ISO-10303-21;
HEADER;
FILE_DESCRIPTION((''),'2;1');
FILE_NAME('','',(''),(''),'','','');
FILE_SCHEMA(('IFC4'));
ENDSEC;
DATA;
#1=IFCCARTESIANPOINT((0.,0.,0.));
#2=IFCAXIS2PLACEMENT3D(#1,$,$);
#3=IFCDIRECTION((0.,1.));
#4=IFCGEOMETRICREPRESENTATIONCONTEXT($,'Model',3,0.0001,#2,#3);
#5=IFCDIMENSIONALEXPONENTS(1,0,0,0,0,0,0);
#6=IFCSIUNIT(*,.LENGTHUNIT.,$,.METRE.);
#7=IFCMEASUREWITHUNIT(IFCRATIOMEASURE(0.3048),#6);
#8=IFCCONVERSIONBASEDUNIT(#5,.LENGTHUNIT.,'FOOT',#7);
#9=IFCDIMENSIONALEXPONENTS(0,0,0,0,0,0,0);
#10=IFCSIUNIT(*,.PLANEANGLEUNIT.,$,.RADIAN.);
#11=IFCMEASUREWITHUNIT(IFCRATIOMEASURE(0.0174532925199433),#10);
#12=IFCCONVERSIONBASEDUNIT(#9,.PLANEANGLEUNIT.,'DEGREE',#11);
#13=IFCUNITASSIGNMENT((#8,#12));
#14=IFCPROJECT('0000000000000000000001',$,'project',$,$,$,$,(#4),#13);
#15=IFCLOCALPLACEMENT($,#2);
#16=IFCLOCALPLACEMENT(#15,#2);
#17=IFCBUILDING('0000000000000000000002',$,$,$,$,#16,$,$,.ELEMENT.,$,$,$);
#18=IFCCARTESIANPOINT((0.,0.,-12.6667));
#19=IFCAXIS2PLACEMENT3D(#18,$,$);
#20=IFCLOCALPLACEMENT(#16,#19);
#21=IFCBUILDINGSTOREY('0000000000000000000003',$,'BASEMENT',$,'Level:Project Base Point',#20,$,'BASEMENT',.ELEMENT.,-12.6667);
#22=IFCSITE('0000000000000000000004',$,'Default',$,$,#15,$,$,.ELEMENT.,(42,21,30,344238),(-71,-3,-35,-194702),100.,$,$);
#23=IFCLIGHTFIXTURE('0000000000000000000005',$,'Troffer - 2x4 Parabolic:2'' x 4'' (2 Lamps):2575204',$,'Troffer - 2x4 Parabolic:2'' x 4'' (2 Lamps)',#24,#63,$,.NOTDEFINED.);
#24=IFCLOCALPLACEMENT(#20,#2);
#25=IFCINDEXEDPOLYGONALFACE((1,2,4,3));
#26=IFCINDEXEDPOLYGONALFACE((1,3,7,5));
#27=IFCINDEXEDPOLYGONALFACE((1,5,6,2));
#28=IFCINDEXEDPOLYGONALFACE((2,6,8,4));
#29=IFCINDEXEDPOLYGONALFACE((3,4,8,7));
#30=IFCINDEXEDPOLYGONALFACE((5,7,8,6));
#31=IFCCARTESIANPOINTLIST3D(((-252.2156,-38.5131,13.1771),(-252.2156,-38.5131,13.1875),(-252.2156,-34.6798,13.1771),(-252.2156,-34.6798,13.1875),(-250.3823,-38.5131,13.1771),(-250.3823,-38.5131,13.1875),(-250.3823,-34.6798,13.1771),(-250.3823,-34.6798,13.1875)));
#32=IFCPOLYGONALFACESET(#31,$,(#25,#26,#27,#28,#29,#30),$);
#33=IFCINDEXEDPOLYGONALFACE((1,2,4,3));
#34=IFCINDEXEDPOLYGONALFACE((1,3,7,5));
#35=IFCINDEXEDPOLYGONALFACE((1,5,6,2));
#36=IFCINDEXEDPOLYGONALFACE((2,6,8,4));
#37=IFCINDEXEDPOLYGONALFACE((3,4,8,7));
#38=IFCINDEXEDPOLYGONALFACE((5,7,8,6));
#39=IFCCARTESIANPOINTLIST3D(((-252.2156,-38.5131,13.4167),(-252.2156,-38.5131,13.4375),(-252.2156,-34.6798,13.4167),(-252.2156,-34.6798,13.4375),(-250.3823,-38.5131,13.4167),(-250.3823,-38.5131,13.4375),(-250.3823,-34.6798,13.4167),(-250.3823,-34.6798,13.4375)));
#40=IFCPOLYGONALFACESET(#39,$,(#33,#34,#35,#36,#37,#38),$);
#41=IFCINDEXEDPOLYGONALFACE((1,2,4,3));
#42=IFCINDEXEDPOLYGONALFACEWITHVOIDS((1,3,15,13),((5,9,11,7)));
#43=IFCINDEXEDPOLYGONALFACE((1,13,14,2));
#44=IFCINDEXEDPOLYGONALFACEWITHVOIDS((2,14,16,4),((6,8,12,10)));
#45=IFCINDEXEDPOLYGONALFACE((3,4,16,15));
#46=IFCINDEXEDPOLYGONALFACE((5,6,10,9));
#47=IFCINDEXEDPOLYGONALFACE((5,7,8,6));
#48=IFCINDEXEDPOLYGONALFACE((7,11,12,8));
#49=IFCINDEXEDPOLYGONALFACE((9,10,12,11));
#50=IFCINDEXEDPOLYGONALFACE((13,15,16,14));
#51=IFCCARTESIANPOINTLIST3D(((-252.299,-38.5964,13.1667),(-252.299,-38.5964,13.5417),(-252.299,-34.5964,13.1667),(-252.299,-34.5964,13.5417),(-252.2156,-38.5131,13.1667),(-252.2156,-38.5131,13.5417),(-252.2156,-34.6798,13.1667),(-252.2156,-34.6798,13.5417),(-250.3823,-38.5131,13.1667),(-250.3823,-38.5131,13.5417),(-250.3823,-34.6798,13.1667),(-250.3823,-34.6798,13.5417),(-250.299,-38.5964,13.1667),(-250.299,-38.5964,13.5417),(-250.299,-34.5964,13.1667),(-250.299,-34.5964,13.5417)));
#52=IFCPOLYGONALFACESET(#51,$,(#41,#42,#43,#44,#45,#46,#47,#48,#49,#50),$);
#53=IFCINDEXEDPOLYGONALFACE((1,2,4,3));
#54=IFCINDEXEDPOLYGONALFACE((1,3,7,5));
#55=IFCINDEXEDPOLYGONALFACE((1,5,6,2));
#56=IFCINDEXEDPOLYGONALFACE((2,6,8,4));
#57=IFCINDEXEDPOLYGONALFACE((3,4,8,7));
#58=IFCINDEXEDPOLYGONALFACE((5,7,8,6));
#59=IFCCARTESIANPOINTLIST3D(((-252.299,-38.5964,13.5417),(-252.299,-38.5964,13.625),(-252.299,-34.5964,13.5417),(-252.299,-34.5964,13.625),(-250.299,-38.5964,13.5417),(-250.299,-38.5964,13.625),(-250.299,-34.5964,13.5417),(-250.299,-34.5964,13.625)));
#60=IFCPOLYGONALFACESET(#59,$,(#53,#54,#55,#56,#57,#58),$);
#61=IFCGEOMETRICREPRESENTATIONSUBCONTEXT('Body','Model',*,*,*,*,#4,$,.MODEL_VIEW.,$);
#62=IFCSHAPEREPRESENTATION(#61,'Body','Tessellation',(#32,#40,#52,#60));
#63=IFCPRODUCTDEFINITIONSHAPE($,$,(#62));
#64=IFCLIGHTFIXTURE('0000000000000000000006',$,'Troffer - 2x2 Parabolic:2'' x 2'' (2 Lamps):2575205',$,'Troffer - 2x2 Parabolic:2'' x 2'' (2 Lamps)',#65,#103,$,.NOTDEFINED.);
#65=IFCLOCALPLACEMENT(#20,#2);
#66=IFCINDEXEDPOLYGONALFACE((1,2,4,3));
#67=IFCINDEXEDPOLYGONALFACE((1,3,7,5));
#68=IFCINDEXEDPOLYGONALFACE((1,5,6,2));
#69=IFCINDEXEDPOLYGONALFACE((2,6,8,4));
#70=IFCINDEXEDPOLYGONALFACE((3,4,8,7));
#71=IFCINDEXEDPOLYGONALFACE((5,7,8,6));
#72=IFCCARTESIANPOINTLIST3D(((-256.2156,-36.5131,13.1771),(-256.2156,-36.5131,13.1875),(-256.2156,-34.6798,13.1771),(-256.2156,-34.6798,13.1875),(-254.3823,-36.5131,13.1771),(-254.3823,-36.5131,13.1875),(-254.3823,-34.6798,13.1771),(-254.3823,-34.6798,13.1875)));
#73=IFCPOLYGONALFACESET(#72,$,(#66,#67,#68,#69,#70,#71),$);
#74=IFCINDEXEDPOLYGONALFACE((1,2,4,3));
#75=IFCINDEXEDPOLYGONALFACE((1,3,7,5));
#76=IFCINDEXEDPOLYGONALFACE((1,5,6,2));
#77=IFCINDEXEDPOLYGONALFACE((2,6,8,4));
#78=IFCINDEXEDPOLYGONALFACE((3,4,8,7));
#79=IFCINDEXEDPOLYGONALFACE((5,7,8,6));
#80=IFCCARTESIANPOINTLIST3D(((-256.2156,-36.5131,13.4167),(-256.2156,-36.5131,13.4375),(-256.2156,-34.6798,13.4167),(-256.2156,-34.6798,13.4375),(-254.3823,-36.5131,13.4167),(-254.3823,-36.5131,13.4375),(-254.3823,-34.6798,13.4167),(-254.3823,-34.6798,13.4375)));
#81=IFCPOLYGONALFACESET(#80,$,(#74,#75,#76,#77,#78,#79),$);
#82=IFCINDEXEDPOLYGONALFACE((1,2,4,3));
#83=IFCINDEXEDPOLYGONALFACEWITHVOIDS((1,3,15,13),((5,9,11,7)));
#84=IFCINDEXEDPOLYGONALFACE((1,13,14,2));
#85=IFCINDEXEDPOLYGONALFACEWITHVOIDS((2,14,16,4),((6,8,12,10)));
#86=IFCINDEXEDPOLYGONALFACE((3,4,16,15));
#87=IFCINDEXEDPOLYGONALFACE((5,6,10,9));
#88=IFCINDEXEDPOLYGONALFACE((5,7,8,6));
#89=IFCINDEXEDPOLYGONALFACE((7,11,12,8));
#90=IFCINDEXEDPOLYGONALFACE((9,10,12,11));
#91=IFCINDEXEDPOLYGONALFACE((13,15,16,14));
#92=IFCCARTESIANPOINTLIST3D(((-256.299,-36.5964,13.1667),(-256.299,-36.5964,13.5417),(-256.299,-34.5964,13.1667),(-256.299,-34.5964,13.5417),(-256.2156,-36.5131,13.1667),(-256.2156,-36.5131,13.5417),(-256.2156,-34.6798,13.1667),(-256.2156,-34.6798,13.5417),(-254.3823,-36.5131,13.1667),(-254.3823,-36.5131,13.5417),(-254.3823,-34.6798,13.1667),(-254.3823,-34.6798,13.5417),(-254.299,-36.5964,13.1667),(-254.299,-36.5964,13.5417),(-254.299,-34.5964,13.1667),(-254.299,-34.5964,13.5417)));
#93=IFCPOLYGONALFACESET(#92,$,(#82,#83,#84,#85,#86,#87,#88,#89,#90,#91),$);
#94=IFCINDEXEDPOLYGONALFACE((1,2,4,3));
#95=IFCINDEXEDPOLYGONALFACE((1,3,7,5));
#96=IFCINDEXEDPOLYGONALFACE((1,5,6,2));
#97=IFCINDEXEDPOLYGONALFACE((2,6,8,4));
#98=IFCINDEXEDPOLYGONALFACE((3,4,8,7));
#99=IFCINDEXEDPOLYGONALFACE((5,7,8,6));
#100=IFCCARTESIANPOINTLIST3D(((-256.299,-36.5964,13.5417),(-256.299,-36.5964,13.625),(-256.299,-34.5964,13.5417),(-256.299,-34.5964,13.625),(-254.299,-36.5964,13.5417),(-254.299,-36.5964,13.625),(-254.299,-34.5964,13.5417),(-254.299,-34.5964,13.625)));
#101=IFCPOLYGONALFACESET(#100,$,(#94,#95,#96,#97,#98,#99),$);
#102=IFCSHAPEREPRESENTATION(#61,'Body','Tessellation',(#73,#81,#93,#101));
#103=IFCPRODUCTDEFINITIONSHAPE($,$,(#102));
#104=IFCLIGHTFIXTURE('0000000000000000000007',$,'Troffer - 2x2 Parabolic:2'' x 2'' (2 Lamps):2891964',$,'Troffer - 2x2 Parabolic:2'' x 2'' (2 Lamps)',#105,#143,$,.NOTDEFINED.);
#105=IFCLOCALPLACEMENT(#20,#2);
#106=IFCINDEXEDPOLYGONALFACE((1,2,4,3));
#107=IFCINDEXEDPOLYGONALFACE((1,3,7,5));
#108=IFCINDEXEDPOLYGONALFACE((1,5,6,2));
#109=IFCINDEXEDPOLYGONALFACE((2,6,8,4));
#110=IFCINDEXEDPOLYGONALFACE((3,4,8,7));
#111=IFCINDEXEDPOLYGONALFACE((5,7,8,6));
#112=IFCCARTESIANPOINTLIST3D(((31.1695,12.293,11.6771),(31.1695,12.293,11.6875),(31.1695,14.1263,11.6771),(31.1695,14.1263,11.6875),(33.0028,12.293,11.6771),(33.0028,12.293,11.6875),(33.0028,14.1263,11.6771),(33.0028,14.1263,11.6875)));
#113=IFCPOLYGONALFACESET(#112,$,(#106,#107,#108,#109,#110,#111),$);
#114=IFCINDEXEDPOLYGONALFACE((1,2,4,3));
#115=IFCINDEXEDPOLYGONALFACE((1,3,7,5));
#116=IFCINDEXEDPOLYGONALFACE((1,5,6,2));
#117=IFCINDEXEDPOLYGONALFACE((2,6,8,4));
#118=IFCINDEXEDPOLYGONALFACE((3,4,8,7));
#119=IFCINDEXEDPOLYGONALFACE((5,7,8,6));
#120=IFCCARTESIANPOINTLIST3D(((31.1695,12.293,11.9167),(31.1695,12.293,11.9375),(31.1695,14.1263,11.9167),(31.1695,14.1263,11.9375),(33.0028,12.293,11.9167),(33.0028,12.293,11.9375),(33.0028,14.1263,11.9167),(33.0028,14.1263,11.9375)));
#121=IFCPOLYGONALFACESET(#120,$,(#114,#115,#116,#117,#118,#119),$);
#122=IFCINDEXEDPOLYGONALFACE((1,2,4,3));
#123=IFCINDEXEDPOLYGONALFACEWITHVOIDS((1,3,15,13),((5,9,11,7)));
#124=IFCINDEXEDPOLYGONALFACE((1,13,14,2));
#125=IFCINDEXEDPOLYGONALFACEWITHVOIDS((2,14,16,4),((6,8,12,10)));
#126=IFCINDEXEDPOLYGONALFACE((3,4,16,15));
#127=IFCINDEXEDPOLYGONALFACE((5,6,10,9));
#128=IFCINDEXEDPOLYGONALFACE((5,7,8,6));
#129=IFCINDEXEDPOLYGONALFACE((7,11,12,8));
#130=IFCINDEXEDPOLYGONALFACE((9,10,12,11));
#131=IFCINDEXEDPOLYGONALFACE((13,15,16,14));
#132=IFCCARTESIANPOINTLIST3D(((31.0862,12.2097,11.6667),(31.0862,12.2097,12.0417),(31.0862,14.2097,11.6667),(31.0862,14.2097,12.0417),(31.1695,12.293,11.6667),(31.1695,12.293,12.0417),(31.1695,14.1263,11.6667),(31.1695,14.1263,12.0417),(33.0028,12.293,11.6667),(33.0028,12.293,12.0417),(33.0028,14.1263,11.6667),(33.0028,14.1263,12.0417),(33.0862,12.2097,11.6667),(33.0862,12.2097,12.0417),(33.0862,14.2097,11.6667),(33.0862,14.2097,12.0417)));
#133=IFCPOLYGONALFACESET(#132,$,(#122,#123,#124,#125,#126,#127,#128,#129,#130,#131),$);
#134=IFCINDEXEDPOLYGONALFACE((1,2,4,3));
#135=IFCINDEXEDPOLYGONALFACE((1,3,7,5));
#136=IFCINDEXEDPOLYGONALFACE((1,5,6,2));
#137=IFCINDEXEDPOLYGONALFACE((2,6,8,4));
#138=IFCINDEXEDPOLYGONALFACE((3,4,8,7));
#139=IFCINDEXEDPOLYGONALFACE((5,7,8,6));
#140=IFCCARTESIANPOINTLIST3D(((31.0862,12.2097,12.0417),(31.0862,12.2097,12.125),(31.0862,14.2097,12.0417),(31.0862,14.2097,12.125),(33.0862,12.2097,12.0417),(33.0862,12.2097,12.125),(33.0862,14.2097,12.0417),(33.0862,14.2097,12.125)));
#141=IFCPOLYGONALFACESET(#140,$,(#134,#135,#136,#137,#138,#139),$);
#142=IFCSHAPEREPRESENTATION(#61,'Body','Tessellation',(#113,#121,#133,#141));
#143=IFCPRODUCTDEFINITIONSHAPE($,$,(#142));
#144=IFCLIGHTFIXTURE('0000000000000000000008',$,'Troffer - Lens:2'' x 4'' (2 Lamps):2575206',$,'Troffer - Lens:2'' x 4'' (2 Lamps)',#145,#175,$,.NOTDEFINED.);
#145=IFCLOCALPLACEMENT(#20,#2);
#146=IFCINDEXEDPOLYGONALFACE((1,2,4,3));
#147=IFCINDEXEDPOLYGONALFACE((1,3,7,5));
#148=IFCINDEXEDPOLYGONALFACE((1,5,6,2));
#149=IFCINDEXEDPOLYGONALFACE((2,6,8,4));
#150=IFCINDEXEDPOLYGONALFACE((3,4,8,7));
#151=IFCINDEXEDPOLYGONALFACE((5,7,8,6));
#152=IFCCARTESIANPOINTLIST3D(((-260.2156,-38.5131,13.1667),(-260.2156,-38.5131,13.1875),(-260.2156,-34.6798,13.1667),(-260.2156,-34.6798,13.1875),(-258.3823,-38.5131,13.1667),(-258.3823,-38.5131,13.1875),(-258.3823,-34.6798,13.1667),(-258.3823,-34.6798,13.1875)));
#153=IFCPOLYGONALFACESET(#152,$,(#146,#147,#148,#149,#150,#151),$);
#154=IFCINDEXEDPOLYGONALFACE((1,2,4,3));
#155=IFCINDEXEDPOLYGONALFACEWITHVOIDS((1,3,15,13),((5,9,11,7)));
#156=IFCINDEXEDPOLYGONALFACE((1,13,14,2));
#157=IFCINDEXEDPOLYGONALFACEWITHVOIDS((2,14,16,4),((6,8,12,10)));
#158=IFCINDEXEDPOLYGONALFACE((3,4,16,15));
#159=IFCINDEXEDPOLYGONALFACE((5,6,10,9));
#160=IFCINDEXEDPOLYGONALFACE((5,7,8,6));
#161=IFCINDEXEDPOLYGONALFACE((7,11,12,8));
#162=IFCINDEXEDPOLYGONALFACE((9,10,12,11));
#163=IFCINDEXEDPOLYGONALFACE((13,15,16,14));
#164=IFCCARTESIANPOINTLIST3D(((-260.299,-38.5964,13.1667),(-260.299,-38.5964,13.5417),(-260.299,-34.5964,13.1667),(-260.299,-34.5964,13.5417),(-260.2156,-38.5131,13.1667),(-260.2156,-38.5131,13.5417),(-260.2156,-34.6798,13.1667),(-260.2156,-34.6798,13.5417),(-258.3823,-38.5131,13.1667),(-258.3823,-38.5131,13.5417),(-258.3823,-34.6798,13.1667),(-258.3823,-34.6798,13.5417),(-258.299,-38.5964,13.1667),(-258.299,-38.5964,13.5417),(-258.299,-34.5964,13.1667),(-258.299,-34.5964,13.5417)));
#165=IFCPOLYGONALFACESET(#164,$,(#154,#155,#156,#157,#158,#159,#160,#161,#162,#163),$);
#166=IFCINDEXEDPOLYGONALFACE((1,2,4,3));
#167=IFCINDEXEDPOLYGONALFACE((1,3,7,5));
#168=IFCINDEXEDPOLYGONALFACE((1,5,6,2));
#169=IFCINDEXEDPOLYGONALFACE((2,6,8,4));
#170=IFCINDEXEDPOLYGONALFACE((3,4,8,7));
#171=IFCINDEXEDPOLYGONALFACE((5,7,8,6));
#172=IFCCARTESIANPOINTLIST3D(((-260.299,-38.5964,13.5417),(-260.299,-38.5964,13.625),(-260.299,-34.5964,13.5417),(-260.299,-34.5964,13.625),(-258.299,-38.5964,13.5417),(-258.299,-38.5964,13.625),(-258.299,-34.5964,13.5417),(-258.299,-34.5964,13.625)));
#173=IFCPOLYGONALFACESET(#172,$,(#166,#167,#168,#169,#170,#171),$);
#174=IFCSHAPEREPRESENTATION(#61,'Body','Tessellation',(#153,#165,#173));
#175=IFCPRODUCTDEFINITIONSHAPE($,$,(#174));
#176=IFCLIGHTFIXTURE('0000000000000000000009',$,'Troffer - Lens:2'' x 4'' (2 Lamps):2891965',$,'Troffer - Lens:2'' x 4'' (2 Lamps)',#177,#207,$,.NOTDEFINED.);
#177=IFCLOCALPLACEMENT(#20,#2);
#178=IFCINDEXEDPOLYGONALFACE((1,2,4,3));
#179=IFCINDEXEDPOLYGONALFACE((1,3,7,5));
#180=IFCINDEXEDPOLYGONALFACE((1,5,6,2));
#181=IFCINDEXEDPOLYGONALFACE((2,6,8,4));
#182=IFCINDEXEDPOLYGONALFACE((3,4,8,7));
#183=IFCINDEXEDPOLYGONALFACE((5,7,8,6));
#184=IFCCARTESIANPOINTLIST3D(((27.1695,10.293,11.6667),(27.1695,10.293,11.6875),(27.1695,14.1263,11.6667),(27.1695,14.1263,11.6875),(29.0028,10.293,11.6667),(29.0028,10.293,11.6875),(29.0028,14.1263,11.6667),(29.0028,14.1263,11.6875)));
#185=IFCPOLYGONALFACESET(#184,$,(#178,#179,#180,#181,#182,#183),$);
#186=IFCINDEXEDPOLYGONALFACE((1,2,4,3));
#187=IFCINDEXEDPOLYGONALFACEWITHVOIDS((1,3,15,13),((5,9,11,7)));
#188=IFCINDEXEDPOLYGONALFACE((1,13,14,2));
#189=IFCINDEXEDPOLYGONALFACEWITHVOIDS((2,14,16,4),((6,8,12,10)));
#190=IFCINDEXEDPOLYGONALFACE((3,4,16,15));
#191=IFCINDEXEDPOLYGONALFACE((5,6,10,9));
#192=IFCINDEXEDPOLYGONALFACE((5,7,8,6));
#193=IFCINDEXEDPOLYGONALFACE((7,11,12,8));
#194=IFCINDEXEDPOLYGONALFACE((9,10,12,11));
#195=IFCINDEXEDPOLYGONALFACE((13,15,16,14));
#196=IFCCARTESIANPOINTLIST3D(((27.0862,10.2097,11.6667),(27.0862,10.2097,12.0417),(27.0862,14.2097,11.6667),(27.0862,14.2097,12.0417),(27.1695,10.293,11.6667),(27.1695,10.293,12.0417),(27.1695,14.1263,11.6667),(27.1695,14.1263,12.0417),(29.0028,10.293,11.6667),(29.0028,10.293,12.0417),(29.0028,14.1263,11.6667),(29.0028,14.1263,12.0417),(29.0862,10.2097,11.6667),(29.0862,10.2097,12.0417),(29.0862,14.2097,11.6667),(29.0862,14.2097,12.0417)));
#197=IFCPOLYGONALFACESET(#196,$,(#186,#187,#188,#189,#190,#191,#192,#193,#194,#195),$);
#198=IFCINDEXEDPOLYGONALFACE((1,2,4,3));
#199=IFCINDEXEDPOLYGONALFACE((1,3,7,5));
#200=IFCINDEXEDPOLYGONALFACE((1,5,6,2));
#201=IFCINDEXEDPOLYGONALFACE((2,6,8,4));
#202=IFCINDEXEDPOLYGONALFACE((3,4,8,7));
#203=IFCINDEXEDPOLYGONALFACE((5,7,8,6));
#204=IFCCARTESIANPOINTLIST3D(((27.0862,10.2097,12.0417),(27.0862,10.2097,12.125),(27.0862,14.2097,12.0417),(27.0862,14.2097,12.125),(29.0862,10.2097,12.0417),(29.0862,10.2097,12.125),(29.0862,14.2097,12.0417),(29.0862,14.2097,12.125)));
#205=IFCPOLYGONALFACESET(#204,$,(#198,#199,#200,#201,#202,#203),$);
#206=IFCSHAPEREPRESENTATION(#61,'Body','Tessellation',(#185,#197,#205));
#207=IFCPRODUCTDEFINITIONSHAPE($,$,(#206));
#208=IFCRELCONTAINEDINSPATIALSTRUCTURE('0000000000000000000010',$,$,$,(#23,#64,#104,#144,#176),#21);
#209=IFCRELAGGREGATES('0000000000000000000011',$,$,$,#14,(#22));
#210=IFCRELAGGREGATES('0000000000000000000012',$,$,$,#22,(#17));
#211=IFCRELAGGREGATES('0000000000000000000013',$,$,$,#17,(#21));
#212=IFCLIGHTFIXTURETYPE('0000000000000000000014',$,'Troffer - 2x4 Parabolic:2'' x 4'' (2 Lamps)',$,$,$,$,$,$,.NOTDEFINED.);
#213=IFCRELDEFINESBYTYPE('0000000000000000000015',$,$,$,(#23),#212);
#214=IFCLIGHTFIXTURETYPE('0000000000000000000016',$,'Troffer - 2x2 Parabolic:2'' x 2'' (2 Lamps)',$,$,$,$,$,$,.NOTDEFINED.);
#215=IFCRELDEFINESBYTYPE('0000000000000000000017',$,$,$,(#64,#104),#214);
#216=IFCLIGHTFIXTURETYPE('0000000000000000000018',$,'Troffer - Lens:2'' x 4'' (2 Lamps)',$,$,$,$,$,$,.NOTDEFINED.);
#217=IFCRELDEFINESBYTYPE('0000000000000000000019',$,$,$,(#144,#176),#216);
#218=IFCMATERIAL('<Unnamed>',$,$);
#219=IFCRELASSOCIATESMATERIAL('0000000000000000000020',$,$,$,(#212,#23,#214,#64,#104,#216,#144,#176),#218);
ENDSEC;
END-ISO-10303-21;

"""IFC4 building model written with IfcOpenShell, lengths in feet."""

from ifc_helpers import new_model, entity, si_unit, converted_unit, direction, frame, frame_2d, origin, origin_2d_with_axis, place, context, subcontext, project, spatial, polyline, rectangle, outline, extrude, source, transform, mapped, material, type_object, type_shapes, element, save


model = new_model("IFC4")

# Units and contexts
model_context = context("Model", 3, precision=0.0001, world=origin(), true_north=direction((0.0, 1.0)))
body_context = subcontext(model_context, "Body", "Model", "MODEL_VIEW")
ifc_project = project(units=[converted_unit("LENGTHUNIT", "FOOT", entity("IfcRatioMeasure", 0.3048), si_unit("LENGTHUNIT", "METRE"), dimensions=[1, 0, 0, 0, 0, 0, 0]), converted_unit("PLANEANGLEUNIT", "DEGREE", entity("IfcRatioMeasure", 0.0174532925199433), si_unit("PLANEANGLEUNIT", "RADIAN"), dimensions=[0, 0, 0, 0, 0, 0, 0])], contexts=[model_context])

# Site, building, storey
site_placement = place(None, origin())
site = spatial("IfcSite", under=ifc_project, at=site_placement, Name="Default", CompositionType="ELEMENT", RefLatitude=(42, 21, 30, 344238), RefLongitude=(-71, -3, -35, -194702), RefElevation=100.0)
building_placement = place(site_placement, origin())
building = spatial("IfcBuilding", under=site, at=building_placement, CompositionType="ELEMENT")
storey_placement = place(building_placement, frame((0.0, 0.0, -12.6667)))
storey = spatial("IfcBuildingStorey", under=building, at=storey_placement, Name="BASEMENT", ObjectType="Level:Project Base Point", LongName="BASEMENT", CompositionType="ELEMENT", Elevation=-12.6667)

# Light fixtures
ifc_material_1 = material(Name="<Unnamed>")
light_fixture_type_1 = type_object("IfcLightFixtureType", Name="Troffer - 2x4 Parabolic:2' x 4' (2 Lamps)", PredefinedType="NOTDEFINED", material=ifc_material_1)
shared_shape_1 = source(origin(), body_context, "Body", "SweptSolid", [
    extrude(rectangle(XDim=3.8333, YDim=1.8333, at=frame_2d((0.0, 0.0), x_axis=(1.0, 0.0))), frame((2.0, 1.0, 0.0104), z_axis=(0.0, 0.0, 1.0), x_axis=(-1.0, 0.0, 0.0)), (0.0, 0.0, 1.0), 0.0104),
    extrude(rectangle(XDim=3.8333, YDim=1.8333, at=origin_2d_with_axis()), frame((2.0, 1.0, 0.25), z_axis=(0.0, 0.0, 1.0), x_axis=(-1.0, 0.0, 0.0)), (0.0, 0.0, 1.0), 0.0208),
    extrude(outline(polyline([(-2.0, -1.0), (2.0, -1.0), (2.0, 1.0), (-2.0, 1.0), (-2.0, -1.0)]), holes=[polyline([(-1.9167, -0.9167), (-1.9167, 0.9167), (1.9167, 0.9167), (1.9167, -0.9167), (-1.9167, -0.9167)])]), frame((2.0, 1.0, 0.0), z_axis=(0.0, 0.0, 1.0), x_axis=(-1.0, 0.0, 0.0)), (0.0, 0.0, 1.0), 0.375),
    extrude(rectangle(XDim=4.0, YDim=2.0, at=frame_2d((0.0, 0.0), x_axis=(1.0, 0.0))), frame((2.0, 1.0, 0.375), z_axis=(0.0, 0.0, 1.0), x_axis=(-1.0, 0.0, 0.0)), (0.0, 0.0, 1.0), 0.0833),
])
type_shapes(light_fixture_type_1, [shared_shape_1])
light_fixture_1_placement = place(storey_placement, frame((-250.299, -38.5964, 13.1667), z_axis=(0.0, 0.0, 1.0), x_axis=(0.0, 1.0, 0.0)))
element("IfcLightFixture", 1, at=light_fixture_1_placement, inside=storey, type_object=light_fixture_type_1, material=ifc_material_1, Name="Troffer - 2x4 Parabolic:2' x 4' (2 Lamps):2575204", ObjectType="Troffer - 2x4 Parabolic:2' x 4' (2 Lamps)", PredefinedType="NOTDEFINED", context=body_context, shape_type="MappedRepresentation", body=[
    mapped(shared_shape_1, transform((0.0, 0.0, 0.0), scale=1.0)),
])
light_fixture_type_2 = type_object("IfcLightFixtureType", Name="Troffer - 2x2 Parabolic:2' x 2' (2 Lamps)", PredefinedType="NOTDEFINED", material=ifc_material_1)
shared_shape_2 = source(origin(), body_context, "Body", "SweptSolid", [
    extrude(rectangle(XDim=1.8333, YDim=1.8333, at=origin_2d_with_axis()), frame((1.0, 1.0, 0.0104), z_axis=(0.0, 0.0, 1.0), x_axis=(-1.0, 0.0, 0.0)), (0.0, 0.0, 1.0), 0.0104),
    extrude(rectangle(XDim=1.8333, YDim=1.8333, at=origin_2d_with_axis()), frame((1.0, 1.0, 0.25), z_axis=(0.0, 0.0, 1.0), x_axis=(-1.0, 0.0, 0.0)), (0.0, 0.0, 1.0), 0.0208),
    extrude(outline(polyline([(-1.0, -1.0), (1.0, -1.0), (1.0, 1.0), (-1.0, 1.0), (-1.0, -1.0)]), holes=[polyline([(-0.9167, -0.9167), (-0.9167, 0.9167), (0.9167, 0.9167), (0.9167, -0.9167), (-0.9167, -0.9167)])]), frame((1.0, 1.0, 0.0), z_axis=(0.0, 0.0, 1.0), x_axis=(-1.0, 0.0, 0.0)), (0.0, 0.0, 1.0), 0.375),
    extrude(rectangle(XDim=2.0, YDim=2.0, at=origin_2d_with_axis()), frame((1.0, 1.0, 0.375), z_axis=(0.0, 0.0, 1.0), x_axis=(-1.0, 0.0, 0.0)), (0.0, 0.0, 1.0), 0.0833),
])
type_shapes(light_fixture_type_2, [shared_shape_2])
for number, where, name in (
    (2, (-256.299, -36.5964, 13.1667), "Troffer - 2x2 Parabolic:2' x 2' (2 Lamps):2575205"),
    (3, (31.0862, 12.2097, 11.6667), "Troffer - 2x2 Parabolic:2' x 2' (2 Lamps):2891964"),
):
    element("IfcLightFixture", number, at=place(storey_placement, frame(where)), inside=storey, type_object=light_fixture_type_2, material=ifc_material_1, Name=name, ObjectType="Troffer - 2x2 Parabolic:2' x 2' (2 Lamps)", PredefinedType="NOTDEFINED", context=body_context, shape_type="MappedRepresentation", body=[
        mapped(shared_shape_2, transform((0.0, 0.0, 0.0), scale=1.0)),
    ])
light_fixture_type_3 = type_object("IfcLightFixtureType", Name="Troffer - Lens:2' x 4' (2 Lamps)", PredefinedType="NOTDEFINED", material=ifc_material_1)
shared_shape_3 = source(origin(), body_context, "Body", "SweptSolid", [
    extrude(rectangle(XDim=3.8333, YDim=1.8333, at=origin_2d_with_axis()), frame((2.0, 1.0, 0.0), z_axis=(0.0, 0.0, 1.0), x_axis=(-1.0, 0.0, 0.0)), (0.0, 0.0, 1.0), 0.0208),
    extrude(outline(polyline([(-2.0, -1.0), (2.0, -1.0), (2.0, 1.0), (-2.0, 1.0), (-2.0, -1.0)]), holes=[polyline([(-1.9167, -0.9167), (-1.9167, 0.9167), (1.9167, 0.9167), (1.9167, -0.9167), (-1.9167, -0.9167)])]), frame((2.0, 1.0, 0.0), z_axis=(0.0, 0.0, 1.0), x_axis=(-1.0, 0.0, 0.0)), (0.0, 0.0, 1.0), 0.375),
    extrude(rectangle(XDim=4.0, YDim=2.0, at=frame_2d((0.0, 0.0), x_axis=(1.0, 0.0))), frame((2.0, 1.0, 0.375), z_axis=(0.0, 0.0, 1.0), x_axis=(-1.0, 0.0, 0.0)), (0.0, 0.0, 1.0), 0.0833),
])
type_shapes(light_fixture_type_3, [shared_shape_3])
for number, where, z_axis, x_axis, name in (
    (4, (-258.299, -38.5964, 13.1667), (0.0, 0.0, 1.0), (0.0, 1.0, 0.0), "Troffer - Lens:2' x 4' (2 Lamps):2575206"),
    (5, (29.0862, 10.2097, 11.6667), (0.0, 0.0, 1.0), (0.0, 1.0, 0.0), "Troffer - Lens:2' x 4' (2 Lamps):2891965"),
):
    element("IfcLightFixture", number, at=place(storey_placement, frame(where, z_axis=z_axis, x_axis=x_axis)), inside=storey, type_object=light_fixture_type_3, material=ifc_material_1, Name=name, ObjectType="Troffer - Lens:2' x 4' (2 Lamps)", PredefinedType="NOTDEFINED", context=body_context, shape_type="MappedRepresentation", body=[
        mapped(shared_shape_3, transform((0.0, 0.0, 0.0), scale=1.0)),
    ])

save(model, "model.ifc")
